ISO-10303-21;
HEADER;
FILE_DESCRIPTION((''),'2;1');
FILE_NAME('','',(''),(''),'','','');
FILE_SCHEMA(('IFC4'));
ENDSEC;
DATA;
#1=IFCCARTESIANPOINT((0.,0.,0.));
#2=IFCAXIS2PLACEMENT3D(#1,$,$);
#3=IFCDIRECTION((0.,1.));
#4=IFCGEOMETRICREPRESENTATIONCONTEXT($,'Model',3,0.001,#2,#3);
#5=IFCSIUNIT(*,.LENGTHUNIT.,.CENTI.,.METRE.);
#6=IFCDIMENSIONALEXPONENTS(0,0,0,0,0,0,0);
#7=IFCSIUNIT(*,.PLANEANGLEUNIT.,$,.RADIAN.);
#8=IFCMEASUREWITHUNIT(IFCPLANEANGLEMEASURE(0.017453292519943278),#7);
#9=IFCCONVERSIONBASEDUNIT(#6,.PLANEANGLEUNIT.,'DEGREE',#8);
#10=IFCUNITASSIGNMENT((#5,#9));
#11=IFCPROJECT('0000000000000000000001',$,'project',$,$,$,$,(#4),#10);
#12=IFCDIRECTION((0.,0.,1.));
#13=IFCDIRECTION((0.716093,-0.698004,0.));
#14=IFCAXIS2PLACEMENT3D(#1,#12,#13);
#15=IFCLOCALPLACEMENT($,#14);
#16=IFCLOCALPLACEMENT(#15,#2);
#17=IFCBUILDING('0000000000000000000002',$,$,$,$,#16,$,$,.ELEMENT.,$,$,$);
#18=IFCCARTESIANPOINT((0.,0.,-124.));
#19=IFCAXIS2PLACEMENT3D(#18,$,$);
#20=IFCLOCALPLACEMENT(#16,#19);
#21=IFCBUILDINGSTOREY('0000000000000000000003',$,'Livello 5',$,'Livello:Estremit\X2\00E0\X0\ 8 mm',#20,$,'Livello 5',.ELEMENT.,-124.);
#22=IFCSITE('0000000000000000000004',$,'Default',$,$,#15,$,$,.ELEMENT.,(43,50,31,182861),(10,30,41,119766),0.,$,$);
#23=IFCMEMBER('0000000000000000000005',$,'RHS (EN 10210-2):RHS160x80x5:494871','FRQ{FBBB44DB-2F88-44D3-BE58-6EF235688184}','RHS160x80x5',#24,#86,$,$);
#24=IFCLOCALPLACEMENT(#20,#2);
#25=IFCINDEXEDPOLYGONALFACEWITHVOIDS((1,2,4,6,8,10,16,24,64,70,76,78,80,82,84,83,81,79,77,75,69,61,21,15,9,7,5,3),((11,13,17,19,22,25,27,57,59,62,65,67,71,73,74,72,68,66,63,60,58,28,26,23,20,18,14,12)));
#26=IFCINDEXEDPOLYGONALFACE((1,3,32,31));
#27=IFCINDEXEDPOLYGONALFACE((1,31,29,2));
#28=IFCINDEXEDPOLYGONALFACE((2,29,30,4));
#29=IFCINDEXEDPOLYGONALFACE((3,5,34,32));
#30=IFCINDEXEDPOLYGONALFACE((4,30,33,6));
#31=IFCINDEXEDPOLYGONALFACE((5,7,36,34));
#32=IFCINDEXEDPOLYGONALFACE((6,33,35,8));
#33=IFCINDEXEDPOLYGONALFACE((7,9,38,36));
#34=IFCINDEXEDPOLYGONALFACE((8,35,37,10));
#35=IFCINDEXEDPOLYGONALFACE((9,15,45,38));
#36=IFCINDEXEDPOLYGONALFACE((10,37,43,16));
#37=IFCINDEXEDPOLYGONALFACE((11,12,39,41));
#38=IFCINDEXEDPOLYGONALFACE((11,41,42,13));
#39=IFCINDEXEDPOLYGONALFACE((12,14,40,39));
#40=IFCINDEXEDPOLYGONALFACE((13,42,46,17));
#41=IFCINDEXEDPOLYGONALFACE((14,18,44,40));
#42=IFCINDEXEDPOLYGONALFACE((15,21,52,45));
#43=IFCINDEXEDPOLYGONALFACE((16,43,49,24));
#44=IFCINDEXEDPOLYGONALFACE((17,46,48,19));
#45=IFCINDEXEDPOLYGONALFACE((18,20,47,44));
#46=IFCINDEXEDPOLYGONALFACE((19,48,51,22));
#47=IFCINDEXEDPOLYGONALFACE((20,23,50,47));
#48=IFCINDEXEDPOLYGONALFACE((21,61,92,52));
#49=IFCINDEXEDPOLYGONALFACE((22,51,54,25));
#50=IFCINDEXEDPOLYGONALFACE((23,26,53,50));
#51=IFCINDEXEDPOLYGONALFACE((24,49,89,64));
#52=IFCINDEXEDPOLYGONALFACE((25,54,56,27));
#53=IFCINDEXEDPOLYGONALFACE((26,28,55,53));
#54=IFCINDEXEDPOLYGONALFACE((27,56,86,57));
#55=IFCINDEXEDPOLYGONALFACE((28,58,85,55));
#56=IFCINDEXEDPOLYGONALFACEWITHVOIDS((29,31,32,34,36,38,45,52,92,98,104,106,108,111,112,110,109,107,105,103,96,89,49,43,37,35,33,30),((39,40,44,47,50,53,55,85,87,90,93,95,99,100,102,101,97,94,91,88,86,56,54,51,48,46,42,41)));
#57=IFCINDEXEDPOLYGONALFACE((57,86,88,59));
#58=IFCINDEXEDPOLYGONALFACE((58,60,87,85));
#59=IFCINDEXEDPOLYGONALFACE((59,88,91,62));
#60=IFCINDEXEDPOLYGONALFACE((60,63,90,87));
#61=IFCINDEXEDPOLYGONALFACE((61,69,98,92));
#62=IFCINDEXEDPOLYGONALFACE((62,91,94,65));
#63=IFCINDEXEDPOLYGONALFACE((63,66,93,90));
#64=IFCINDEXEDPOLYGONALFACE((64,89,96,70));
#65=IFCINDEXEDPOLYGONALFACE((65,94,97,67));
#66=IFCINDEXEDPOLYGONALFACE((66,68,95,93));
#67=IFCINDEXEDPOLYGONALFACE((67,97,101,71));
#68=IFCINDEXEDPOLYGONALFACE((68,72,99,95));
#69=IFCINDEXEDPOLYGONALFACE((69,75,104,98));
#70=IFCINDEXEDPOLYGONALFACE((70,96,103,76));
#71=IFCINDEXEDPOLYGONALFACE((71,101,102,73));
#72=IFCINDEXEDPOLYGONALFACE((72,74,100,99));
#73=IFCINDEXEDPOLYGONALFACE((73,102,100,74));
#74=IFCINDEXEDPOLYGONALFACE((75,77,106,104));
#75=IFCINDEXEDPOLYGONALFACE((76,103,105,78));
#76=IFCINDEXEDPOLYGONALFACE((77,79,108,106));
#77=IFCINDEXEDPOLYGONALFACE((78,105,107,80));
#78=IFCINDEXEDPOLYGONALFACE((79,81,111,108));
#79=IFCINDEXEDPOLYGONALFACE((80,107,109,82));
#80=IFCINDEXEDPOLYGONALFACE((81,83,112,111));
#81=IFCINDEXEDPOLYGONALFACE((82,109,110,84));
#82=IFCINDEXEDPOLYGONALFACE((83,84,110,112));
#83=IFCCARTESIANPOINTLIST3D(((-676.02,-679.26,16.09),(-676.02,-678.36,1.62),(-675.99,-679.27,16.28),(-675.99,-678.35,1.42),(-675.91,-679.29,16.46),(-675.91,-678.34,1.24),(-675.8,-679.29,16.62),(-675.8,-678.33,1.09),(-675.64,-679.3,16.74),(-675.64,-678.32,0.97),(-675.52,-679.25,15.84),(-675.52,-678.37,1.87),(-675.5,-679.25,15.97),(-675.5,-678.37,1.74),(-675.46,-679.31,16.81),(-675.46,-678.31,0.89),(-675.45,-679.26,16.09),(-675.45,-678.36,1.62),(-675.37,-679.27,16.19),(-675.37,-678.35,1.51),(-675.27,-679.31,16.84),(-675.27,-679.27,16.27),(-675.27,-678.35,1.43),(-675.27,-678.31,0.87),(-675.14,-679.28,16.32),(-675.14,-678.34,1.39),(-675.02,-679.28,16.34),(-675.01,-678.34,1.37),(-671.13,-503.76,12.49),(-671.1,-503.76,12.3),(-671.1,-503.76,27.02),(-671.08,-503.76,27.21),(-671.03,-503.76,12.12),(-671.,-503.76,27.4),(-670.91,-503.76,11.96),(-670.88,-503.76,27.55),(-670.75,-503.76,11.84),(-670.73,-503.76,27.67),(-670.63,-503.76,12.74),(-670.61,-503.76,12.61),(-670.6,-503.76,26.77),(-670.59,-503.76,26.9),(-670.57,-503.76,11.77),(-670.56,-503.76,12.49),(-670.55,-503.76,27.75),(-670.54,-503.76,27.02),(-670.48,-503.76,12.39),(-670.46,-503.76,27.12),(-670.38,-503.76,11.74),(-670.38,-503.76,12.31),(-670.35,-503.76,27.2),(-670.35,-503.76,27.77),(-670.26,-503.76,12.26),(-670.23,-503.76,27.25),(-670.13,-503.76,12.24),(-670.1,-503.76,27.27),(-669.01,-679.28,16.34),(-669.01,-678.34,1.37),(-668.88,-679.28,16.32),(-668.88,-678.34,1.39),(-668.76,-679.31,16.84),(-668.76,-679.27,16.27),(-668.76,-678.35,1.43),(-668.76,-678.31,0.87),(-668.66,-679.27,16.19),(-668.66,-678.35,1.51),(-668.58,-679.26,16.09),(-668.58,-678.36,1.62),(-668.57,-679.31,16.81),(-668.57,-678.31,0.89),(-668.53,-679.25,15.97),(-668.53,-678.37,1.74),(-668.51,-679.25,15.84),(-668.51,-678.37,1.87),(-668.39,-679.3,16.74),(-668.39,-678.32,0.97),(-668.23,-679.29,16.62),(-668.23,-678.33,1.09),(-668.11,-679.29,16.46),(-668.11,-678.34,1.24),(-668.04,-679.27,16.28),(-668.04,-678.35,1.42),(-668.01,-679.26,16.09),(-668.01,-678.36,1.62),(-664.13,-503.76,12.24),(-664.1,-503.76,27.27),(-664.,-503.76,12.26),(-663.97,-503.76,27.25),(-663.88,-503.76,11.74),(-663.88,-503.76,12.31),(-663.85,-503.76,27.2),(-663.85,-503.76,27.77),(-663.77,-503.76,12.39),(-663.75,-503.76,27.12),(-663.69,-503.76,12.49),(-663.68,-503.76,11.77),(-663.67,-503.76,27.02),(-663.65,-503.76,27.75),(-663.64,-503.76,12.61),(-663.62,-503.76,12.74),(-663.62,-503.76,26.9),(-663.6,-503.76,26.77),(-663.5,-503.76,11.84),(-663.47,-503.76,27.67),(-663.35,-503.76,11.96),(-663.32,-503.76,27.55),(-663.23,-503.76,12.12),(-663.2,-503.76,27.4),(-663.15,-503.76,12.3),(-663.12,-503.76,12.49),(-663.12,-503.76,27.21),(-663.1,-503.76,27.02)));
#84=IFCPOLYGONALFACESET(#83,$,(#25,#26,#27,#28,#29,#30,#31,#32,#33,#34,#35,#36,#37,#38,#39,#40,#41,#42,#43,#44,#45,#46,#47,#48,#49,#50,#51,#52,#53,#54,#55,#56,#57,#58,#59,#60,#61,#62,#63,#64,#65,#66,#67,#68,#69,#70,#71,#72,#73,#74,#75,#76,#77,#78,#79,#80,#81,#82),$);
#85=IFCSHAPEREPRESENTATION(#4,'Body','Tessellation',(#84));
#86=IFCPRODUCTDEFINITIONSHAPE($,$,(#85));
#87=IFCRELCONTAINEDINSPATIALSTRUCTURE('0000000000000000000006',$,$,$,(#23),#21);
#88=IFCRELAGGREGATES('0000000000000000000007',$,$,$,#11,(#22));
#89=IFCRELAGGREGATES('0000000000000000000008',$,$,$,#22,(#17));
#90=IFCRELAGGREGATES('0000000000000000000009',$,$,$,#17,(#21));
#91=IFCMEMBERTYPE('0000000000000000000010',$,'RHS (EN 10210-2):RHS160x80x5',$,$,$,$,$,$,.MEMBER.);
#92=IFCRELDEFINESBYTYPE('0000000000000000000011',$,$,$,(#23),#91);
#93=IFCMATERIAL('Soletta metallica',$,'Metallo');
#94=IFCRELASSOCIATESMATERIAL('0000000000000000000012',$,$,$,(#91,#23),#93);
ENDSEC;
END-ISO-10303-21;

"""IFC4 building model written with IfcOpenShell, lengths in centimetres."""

from ifc_helpers import new_model, entity, si_unit, converted_unit, direction, frame, origin, origin_2d, place, context, project, spatial, hollow_rectangle, extrude, clip, halfspace, material, type_object, element, save


model = new_model("IFC4")

# Units and contexts
model_context = context("Model", 3, precision=0.001, world=origin(), true_north=direction((0.0, 1.0)))
ifc_project = project(units=[si_unit("LENGTHUNIT", "METRE", prefix="CENTI"), converted_unit("PLANEANGLEUNIT", "DEGREE", entity("IfcPlaneAngleMeasure", 0.017453292519943278), si_unit("PLANEANGLEUNIT", "RADIAN"), dimensions=[0, 0, 0, 0, 0, 0, 0])], contexts=[model_context])

# Site, building, storey
site_placement = place(None, frame((0.0, 0.0, 0.0), z_axis=(0.0, 0.0, 1.0), x_axis=(0.716093, -0.698004, 0.0)))
site = spatial("IfcSite", under=ifc_project, at=site_placement, Name="Default", CompositionType="ELEMENT", RefLatitude=(43, 50, 31, 182861), RefLongitude=(10, 30, 41, 119766), RefElevation=0.0)
building_placement = place(site_placement, origin())
building = spatial("IfcBuilding", under=site, at=building_placement, CompositionType="ELEMENT")
storey_placement = place(building_placement, frame((0.0, 0.0, -124.0)))
storey = spatial("IfcBuildingStorey", under=building, at=storey_placement, Name="Livello 5", ObjectType="Livello:Estremità 8 mm", LongName="Livello 5", CompositionType="ELEMENT", Elevation=-124.0)

# Shared definitions
ifc_material_1 = material(Name="Soletta metallica", Category="Metallo")

# Member
member_type_1 = type_object("IfcMemberType", Name="RHS (EN 10210-2):RHS160x80x5", PredefinedType="MEMBER", material=ifc_material_1)
member_1_placement = place(storey_placement, frame((-673.1, -717.68, 6.43), z_axis=(-0.027926, -0.997677, -0.062135), x_axis=(0.99961, -0.027872, -0.001736)))
element("IfcMember", 1, at=member_1_placement, inside=storey, type_object=member_type_1, material=ifc_material_1, Name="RHS (EN 10210-2):RHS160x80x5:494871", Description="FRQ{FBBB44DB-2F88-44D3-BE58-6EF235688184}", ObjectType="RHS160x80x5", context=model_context, shape_type="Clipping", body=[
    clip(clip(extrude(hollow_rectangle(XDim=8.0, YDim=16.0, WallThickness=0.5, InnerFilletRadius=0.5, OuterFilletRadius=0.75, at=origin_2d()), origin(), (0.0, 0.0, -1.0), 242.93), halfspace(frame((666.85, 102.87, -239.53), z_axis=(0.02798, 0.062159, 0.997674), x_axis=(0.999608, -0.00174, -0.027926)), True)), halfspace(frame((671.88, 71.48, -57.72), z_axis=(-0.027926, 0.000109, -0.99961), x_axis=(-0.999608, 0.00174, 0.027926)), True)),
])

save(model, "model.ifc")
